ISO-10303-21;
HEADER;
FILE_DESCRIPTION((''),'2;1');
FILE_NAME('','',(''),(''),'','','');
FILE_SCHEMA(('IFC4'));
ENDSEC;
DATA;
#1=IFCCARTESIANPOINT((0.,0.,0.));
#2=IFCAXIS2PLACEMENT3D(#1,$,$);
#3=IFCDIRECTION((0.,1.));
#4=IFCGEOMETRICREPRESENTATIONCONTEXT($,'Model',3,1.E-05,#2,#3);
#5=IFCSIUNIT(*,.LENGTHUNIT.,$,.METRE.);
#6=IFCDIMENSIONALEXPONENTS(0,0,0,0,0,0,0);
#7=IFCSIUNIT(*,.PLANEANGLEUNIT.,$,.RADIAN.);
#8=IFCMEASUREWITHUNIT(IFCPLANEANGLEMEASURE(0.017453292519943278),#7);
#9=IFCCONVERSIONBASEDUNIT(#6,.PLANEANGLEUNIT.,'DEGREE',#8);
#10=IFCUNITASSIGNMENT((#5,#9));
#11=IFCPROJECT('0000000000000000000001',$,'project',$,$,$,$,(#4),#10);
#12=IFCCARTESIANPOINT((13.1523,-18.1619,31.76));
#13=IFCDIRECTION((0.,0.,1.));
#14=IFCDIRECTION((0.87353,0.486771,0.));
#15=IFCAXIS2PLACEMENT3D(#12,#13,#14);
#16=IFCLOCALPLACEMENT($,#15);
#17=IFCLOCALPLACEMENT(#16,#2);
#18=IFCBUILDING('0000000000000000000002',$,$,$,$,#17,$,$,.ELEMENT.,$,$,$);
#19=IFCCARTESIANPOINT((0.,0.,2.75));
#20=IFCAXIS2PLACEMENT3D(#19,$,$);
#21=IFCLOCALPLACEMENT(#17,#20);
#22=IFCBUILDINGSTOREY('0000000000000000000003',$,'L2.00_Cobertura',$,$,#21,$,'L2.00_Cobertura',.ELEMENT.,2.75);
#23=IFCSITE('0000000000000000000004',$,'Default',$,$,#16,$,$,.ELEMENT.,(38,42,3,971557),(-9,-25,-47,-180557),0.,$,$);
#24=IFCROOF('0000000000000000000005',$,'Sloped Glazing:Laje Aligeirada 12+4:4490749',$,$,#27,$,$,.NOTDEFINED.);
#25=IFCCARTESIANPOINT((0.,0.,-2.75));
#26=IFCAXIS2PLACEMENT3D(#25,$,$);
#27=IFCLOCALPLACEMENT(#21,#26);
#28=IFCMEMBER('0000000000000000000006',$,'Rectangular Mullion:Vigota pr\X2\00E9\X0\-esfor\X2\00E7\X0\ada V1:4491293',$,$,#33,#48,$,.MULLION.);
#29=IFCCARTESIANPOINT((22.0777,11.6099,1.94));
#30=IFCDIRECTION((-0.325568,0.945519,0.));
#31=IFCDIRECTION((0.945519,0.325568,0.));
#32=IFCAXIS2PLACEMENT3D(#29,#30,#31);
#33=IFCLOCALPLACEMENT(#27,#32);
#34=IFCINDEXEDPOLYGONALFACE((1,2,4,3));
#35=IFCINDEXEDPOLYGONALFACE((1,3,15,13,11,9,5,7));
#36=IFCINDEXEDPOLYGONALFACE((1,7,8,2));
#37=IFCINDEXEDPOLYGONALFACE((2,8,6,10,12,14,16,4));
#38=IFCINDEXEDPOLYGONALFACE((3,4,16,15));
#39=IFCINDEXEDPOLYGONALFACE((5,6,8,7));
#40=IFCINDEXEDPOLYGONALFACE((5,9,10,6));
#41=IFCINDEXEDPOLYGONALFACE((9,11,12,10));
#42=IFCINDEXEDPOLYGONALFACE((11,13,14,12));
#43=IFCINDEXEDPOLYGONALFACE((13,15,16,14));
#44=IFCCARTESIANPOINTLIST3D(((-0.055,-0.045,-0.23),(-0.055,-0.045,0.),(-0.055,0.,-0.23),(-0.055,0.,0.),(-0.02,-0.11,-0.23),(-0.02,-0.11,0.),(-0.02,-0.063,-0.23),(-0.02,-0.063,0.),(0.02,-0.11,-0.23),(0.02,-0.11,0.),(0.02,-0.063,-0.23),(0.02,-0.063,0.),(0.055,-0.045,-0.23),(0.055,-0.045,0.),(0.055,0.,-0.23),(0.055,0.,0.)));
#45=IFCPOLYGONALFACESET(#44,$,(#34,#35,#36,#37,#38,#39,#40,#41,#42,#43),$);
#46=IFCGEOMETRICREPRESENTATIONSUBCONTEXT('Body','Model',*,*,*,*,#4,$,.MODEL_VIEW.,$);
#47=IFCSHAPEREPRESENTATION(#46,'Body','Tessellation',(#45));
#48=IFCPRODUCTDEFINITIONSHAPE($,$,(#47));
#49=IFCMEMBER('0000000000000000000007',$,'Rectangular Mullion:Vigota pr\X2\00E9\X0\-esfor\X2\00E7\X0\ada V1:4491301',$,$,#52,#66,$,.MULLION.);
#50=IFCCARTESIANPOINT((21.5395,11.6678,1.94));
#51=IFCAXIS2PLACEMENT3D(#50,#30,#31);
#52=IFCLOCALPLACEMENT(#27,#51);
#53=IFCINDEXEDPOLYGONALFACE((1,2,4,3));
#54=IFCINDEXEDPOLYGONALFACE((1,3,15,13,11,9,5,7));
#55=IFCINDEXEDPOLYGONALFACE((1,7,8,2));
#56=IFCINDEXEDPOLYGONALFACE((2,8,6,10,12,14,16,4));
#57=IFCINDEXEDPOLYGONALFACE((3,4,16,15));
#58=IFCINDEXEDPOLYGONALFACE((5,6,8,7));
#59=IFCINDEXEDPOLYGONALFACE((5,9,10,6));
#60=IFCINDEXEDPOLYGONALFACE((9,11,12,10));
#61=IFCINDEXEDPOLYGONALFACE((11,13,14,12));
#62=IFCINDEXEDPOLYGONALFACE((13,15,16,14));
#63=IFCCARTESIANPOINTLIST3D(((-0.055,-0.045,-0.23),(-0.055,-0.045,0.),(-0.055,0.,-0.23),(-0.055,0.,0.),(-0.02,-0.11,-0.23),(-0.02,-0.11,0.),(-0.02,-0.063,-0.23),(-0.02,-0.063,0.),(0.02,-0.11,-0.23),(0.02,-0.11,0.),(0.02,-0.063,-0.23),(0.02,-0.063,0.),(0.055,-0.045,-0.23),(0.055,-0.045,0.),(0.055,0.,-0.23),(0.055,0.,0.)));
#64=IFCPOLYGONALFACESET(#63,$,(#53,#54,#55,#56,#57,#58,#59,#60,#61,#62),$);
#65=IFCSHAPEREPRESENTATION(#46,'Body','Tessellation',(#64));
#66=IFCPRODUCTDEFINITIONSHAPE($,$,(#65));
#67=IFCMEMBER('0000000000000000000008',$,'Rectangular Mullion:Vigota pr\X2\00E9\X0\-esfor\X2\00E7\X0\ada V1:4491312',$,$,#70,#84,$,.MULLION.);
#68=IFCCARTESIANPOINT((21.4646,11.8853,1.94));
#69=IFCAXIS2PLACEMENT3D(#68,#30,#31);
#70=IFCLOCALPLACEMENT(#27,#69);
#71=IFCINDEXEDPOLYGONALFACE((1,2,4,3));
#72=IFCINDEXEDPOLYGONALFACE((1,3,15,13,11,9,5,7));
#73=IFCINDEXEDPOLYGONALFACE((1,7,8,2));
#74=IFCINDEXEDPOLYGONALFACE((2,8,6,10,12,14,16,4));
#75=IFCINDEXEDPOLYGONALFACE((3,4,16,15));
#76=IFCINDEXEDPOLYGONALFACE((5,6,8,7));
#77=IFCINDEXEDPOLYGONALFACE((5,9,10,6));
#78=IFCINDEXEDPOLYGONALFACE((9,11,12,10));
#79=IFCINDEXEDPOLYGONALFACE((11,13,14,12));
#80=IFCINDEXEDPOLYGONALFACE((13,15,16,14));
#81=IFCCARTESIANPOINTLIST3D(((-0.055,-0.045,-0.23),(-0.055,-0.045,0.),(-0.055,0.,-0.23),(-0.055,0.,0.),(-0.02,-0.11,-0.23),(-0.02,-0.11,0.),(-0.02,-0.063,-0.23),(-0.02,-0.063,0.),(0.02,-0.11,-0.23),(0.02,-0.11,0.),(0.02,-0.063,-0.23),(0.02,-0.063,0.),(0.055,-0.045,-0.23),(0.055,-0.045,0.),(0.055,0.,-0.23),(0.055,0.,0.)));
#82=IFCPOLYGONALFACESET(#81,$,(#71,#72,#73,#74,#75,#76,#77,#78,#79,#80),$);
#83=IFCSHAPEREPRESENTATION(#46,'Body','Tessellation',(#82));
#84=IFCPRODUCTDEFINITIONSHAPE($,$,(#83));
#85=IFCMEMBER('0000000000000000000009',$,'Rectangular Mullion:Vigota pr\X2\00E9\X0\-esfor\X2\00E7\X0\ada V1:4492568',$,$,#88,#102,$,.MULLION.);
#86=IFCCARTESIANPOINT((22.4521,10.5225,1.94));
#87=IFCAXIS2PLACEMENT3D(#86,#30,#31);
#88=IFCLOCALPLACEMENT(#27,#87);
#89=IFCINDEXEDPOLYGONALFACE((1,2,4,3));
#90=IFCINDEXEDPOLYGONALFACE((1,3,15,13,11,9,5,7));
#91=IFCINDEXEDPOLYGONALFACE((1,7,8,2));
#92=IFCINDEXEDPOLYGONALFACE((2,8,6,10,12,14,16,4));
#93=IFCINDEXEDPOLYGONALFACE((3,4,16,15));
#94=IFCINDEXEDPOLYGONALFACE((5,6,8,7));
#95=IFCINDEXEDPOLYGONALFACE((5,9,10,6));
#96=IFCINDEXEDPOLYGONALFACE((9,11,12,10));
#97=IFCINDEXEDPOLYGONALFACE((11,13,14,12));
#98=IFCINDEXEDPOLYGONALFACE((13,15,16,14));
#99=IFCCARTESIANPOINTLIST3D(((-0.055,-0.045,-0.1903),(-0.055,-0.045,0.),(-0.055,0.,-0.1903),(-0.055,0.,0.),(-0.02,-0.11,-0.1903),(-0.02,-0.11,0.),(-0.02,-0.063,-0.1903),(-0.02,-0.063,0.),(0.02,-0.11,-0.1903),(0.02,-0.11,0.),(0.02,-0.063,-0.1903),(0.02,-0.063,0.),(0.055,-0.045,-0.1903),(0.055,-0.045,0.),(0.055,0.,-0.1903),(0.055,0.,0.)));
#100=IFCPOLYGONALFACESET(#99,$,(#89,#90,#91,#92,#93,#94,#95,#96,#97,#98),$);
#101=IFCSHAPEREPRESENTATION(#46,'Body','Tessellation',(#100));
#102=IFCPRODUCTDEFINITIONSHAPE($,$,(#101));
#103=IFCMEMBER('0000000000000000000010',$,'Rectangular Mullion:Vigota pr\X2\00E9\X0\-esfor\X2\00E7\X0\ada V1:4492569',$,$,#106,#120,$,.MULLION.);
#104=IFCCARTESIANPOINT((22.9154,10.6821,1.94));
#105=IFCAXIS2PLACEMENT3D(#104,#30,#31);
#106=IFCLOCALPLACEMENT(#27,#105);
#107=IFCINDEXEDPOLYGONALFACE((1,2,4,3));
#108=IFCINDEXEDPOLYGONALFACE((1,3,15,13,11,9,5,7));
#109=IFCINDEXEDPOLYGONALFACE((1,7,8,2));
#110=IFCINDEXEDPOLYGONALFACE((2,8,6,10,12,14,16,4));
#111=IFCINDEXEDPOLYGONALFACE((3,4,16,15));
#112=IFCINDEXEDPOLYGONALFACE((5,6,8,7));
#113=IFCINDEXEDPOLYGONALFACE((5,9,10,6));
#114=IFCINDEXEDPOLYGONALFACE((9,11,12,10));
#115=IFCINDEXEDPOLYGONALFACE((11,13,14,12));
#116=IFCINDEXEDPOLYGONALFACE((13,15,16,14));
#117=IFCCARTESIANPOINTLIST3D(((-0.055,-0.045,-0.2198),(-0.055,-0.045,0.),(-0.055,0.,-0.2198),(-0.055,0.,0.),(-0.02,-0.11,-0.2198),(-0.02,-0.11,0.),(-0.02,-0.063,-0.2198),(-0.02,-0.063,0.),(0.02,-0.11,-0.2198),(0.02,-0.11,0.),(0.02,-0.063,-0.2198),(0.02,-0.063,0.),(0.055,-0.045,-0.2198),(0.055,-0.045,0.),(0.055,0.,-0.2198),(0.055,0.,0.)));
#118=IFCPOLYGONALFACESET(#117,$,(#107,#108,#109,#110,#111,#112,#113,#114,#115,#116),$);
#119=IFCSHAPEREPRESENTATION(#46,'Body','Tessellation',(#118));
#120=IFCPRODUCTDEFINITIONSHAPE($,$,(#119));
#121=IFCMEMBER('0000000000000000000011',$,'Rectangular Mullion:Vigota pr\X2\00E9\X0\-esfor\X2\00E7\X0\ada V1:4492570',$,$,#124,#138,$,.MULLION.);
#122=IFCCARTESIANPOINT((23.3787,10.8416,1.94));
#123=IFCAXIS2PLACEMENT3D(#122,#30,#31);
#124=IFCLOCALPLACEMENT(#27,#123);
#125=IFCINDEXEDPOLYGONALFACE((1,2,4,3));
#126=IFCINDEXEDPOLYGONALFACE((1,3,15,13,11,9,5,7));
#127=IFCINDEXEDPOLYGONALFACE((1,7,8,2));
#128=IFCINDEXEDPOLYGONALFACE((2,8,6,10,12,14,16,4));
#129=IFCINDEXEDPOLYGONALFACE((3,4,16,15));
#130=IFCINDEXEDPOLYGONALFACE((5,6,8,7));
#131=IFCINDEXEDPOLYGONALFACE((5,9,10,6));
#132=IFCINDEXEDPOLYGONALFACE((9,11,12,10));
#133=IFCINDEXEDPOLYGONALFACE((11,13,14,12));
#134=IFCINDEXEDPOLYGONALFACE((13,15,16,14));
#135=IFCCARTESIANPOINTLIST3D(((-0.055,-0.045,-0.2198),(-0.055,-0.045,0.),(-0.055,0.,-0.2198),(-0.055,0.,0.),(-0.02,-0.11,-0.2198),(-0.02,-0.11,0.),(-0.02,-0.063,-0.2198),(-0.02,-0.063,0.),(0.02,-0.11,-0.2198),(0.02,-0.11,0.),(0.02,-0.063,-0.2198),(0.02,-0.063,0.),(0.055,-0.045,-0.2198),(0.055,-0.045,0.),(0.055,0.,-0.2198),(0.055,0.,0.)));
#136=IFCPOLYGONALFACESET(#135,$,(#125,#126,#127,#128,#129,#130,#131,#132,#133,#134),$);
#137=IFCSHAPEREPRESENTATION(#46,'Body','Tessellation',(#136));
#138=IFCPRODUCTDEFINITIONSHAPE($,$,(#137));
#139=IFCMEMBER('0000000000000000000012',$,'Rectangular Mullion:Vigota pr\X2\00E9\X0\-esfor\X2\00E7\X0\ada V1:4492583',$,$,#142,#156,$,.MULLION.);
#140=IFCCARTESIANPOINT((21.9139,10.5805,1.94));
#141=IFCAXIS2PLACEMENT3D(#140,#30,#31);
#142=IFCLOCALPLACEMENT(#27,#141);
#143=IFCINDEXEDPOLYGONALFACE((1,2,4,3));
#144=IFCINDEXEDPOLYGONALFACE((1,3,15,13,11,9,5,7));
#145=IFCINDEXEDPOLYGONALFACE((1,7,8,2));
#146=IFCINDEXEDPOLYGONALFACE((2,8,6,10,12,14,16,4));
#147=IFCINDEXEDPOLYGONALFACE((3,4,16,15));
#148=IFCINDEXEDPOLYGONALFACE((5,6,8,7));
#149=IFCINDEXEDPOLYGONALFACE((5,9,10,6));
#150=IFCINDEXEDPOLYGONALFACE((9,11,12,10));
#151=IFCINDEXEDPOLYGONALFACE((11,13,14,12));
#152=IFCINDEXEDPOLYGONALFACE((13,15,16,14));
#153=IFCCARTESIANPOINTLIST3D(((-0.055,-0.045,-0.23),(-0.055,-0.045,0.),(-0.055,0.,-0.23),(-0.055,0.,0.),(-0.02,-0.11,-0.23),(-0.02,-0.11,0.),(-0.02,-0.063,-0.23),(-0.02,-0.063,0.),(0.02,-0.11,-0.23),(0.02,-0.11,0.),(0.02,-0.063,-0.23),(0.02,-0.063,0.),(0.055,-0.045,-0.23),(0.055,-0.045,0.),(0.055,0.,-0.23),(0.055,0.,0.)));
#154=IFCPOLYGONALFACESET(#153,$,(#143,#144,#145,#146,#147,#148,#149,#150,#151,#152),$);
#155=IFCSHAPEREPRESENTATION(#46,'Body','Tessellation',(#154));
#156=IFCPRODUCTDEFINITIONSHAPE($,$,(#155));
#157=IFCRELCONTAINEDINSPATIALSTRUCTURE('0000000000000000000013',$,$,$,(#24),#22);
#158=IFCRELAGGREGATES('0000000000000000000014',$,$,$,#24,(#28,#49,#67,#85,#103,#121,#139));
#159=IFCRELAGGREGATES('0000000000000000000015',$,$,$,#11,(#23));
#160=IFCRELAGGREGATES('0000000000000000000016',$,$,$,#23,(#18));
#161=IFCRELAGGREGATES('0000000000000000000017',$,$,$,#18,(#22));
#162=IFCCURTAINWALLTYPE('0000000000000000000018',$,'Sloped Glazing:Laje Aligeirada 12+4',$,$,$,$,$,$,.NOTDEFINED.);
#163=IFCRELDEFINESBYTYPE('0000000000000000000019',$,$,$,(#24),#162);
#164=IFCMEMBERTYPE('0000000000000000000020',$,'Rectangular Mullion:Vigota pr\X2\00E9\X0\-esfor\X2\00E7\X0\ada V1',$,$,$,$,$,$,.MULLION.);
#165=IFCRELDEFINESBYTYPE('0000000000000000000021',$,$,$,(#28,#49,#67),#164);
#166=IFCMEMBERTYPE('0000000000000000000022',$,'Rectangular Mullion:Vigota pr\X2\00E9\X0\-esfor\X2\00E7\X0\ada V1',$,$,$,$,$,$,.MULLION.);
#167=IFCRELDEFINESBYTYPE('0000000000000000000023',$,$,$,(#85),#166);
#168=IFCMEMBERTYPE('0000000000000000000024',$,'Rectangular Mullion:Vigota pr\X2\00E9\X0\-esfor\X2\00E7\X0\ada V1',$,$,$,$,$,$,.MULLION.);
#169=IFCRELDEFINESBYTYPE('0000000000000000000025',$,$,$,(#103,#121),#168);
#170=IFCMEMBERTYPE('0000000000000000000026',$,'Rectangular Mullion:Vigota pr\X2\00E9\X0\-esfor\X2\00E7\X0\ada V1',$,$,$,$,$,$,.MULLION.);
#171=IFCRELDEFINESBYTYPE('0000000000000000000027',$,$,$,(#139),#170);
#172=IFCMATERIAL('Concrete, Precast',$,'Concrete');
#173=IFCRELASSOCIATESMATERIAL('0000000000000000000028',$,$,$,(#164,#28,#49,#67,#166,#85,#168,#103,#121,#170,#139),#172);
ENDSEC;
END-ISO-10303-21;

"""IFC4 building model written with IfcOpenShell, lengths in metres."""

from ifc_helpers import new_model, entity, si_unit, converted_unit, direction, frame, origin, place, context, subcontext, project, spatial, indexed_curve, outline, extrude, source, transform, mapped, material, type_object, type_shapes, element, aggregate, save


model = new_model("IFC4")

# Units and contexts
model_context = context("Model", 3, precision=1e-05, world=origin(), true_north=direction((0.0, 1.0)))
body_context = subcontext(model_context, "Body", "Model", "MODEL_VIEW")
ifc_project = project(units=[si_unit("LENGTHUNIT", "METRE"), converted_unit("PLANEANGLEUNIT", "DEGREE", entity("IfcPlaneAngleMeasure", 0.017453292519943278), si_unit("PLANEANGLEUNIT", "RADIAN"), dimensions=[0, 0, 0, 0, 0, 0, 0])], contexts=[model_context])

# Site, building, storey
site_placement = place(None, frame((13.1523, -18.1619, 31.76), z_axis=(0.0, 0.0, 1.0), x_axis=(0.87353, 0.486771, 0.0)))
site = spatial("IfcSite", under=ifc_project, at=site_placement, Name="Default", CompositionType="ELEMENT", RefLatitude=(38, 42, 3, 971557), RefLongitude=(-9, -25, -47, -180557), RefElevation=0.0)
building_placement = place(site_placement, origin())
building = spatial("IfcBuilding", under=site, at=building_placement, CompositionType="ELEMENT")
storey_placement = place(building_placement, frame((0.0, 0.0, 2.75)))
storey = spatial("IfcBuildingStorey", under=building, at=storey_placement, Name="L2.00_Cobertura", LongName="L2.00_Cobertura", CompositionType="ELEMENT", Elevation=2.75)

# Roof, members
curtain_wall_type = type_object("IfcCurtainWallType", Name="Sloped Glazing:Laje Aligeirada 12+4", PredefinedType="NOTDEFINED")
roof_placement = place(storey_placement, frame((0.0, 0.0, -2.75)))
roof = element("IfcRoof", 1, at=roof_placement, inside=storey, type_object=curtain_wall_type, Name="Sloped Glazing:Laje Aligeirada 12+4:4490749", PredefinedType="NOTDEFINED")
ifc_material_1 = material(Name="Concrete, Precast", Category="Concrete")
member_type_1 = type_object("IfcMemberType", Name="Rectangular Mullion:Vigota pré-esforçada V1", PredefinedType="MULLION", material=ifc_material_1)
shared_shape_1 = source(origin(), body_context, "Body", "SweptSolid", [
    extrude(outline(indexed_curve([(-0.055, -0.0545), (0.055, -0.0545), (0.055, -0.0095), (0.02, 0.0085), (0.02, 0.0555), (-0.02, 0.0555), (-0.02, 0.0085), (-0.055, -0.0095), (-0.055, -0.0545)], self_intersect=False)), frame((0.0, -0.0545, -0.23), z_axis=(0.0, 0.0, 1.0), x_axis=(-1.0, 0.0, 0.0)), (0.0, 0.0, 1.0), 0.23),
])
type_shapes(member_type_1, [shared_shape_1])
member_1_placement = place(roof_placement, frame((22.0777, 11.6099, 1.94), z_axis=(-0.325568, 0.945519, 0.0), x_axis=(0.945519, 0.325568, 0.0)))
member_1 = element("IfcMember", 2, at=member_1_placement, type_object=member_type_1, material=ifc_material_1, Name="Rectangular Mullion:Vigota pré-esforçada V1:4491293", PredefinedType="MULLION", context=body_context, shape_type="MappedRepresentation", body=[
    mapped(shared_shape_1, transform((0.0, 0.0, 0.0), scale=1.0)),
])
member_2_placement = place(roof_placement, frame((21.5395, 11.6678, 1.94), z_axis=(-0.325568, 0.945519, 0.0), x_axis=(0.945519, 0.325568, 0.0)))
member_2 = element("IfcMember", 3, at=member_2_placement, type_object=member_type_1, material=ifc_material_1, Name="Rectangular Mullion:Vigota pré-esforçada V1:4491301", PredefinedType="MULLION", context=body_context, shape_type="MappedRepresentation", body=[
    mapped(shared_shape_1, transform((0.0, 0.0, 0.0), scale=1.0)),
])
member_3_placement = place(roof_placement, frame((21.4646, 11.8853, 1.94), z_axis=(-0.325568, 0.945519, 0.0), x_axis=(0.945519, 0.325568, 0.0)))
member_3 = element("IfcMember", 4, at=member_3_placement, type_object=member_type_1, material=ifc_material_1, Name="Rectangular Mullion:Vigota pré-esforçada V1:4491312", PredefinedType="MULLION", context=body_context, shape_type="MappedRepresentation", body=[
    mapped(shared_shape_1, transform((0.0, 0.0, 0.0), scale=1.0)),
])
member_type_2 = type_object("IfcMemberType", Name="Rectangular Mullion:Vigota pré-esforçada V1", PredefinedType="MULLION", material=ifc_material_1)
shared_shape_2 = source(origin(), body_context, "Body", "SweptSolid", [
    extrude(outline(indexed_curve([(-0.055, -0.0545), (0.055, -0.0545), (0.055, -0.0095), (0.02, 0.0085), (0.02, 0.0555), (-0.02, 0.0555), (-0.02, 0.0085), (-0.055, -0.0095), (-0.055, -0.0545)], self_intersect=False)), frame((0.0, -0.0545, -0.1903), z_axis=(0.0, 0.0, 1.0), x_axis=(-1.0, 0.0, 0.0)), (0.0, 0.0, 1.0), 0.1903),
])
type_shapes(member_type_2, [shared_shape_2])
member_4_placement = place(roof_placement, frame((22.4521, 10.5225, 1.94), z_axis=(-0.325568, 0.945519, 0.0), x_axis=(0.945519, 0.325568, 0.0)))
member_4 = element("IfcMember", 5, at=member_4_placement, type_object=member_type_2, material=ifc_material_1, Name="Rectangular Mullion:Vigota pré-esforçada V1:4492568", PredefinedType="MULLION", context=body_context, shape_type="MappedRepresentation", body=[
    mapped(shared_shape_2, transform((0.0, 0.0, 0.0), scale=1.0)),
])
member_type_3 = type_object("IfcMemberType", Name="Rectangular Mullion:Vigota pré-esforçada V1", PredefinedType="MULLION", material=ifc_material_1)
shared_shape_3 = source(origin(), body_context, "Body", "SweptSolid", [
    extrude(outline(indexed_curve([(-0.055, -0.0545), (0.055, -0.0545), (0.055, -0.0095), (0.02, 0.0085), (0.02, 0.0555), (-0.02, 0.0555), (-0.02, 0.0085), (-0.055, -0.0095), (-0.055, -0.0545)], self_intersect=False)), frame((0.0, -0.0545, -0.2198), z_axis=(0.0, 0.0, 1.0), x_axis=(-1.0, 0.0, 0.0)), (0.0, 0.0, 1.0), 0.2198),
])
type_shapes(member_type_3, [shared_shape_3])
member_5_placement = place(roof_placement, frame((22.9154, 10.6821, 1.94), z_axis=(-0.325568, 0.945519, 0.0), x_axis=(0.945519, 0.325568, 0.0)))
member_5 = element("IfcMember", 6, at=member_5_placement, type_object=member_type_3, material=ifc_material_1, Name="Rectangular Mullion:Vigota pré-esforçada V1:4492569", PredefinedType="MULLION", context=body_context, shape_type="MappedRepresentation", body=[
    mapped(shared_shape_3, transform((0.0, 0.0, 0.0), scale=1.0)),
])
member_6_placement = place(roof_placement, frame((23.3787, 10.8416, 1.94), z_axis=(-0.325568, 0.945519, 0.0), x_axis=(0.945519, 0.325568, 0.0)))
member_6 = element("IfcMember", 7, at=member_6_placement, type_object=member_type_3, material=ifc_material_1, Name="Rectangular Mullion:Vigota pré-esforçada V1:4492570", PredefinedType="MULLION", context=body_context, shape_type="MappedRepresentation", body=[
    mapped(shared_shape_3, transform((0.0, 0.0, 0.0), scale=1.0)),
])
member_type_4 = type_object("IfcMemberType", Name="Rectangular Mullion:Vigota pré-esforçada V1", PredefinedType="MULLION", material=ifc_material_1)
shared_shape_4 = source(origin(), body_context, "Body", "SweptSolid", [
    extrude(outline(indexed_curve([(-0.055, -0.0545), (0.055, -0.0545), (0.055, -0.0095), (0.02, 0.0085), (0.02, 0.0555), (-0.02, 0.0555), (-0.02, 0.0085), (-0.055, -0.0095), (-0.055, -0.0545)], self_intersect=False)), frame((0.0, -0.0545, -0.23), z_axis=(0.0, 0.0, 1.0), x_axis=(-1.0, 0.0, 0.0)), (0.0, 0.0, 1.0), 0.23),
])
type_shapes(member_type_4, [shared_shape_4])
member_7_placement = place(roof_placement, frame((21.9139, 10.5805, 1.94), z_axis=(-0.325568, 0.945519, 0.0), x_axis=(0.945519, 0.325568, 0.0)))
member_7 = element("IfcMember", 8, at=member_7_placement, type_object=member_type_4, material=ifc_material_1, Name="Rectangular Mullion:Vigota pré-esforçada V1:4492583", PredefinedType="MULLION", context=body_context, shape_type="MappedRepresentation", body=[
    mapped(shared_shape_4, transform((0.0, 0.0, 0.0), scale=1.0)),
])

aggregate(roof, [member_1, member_2, member_3, member_4, member_5, member_6, member_7])

save(model, "model.ifc")
